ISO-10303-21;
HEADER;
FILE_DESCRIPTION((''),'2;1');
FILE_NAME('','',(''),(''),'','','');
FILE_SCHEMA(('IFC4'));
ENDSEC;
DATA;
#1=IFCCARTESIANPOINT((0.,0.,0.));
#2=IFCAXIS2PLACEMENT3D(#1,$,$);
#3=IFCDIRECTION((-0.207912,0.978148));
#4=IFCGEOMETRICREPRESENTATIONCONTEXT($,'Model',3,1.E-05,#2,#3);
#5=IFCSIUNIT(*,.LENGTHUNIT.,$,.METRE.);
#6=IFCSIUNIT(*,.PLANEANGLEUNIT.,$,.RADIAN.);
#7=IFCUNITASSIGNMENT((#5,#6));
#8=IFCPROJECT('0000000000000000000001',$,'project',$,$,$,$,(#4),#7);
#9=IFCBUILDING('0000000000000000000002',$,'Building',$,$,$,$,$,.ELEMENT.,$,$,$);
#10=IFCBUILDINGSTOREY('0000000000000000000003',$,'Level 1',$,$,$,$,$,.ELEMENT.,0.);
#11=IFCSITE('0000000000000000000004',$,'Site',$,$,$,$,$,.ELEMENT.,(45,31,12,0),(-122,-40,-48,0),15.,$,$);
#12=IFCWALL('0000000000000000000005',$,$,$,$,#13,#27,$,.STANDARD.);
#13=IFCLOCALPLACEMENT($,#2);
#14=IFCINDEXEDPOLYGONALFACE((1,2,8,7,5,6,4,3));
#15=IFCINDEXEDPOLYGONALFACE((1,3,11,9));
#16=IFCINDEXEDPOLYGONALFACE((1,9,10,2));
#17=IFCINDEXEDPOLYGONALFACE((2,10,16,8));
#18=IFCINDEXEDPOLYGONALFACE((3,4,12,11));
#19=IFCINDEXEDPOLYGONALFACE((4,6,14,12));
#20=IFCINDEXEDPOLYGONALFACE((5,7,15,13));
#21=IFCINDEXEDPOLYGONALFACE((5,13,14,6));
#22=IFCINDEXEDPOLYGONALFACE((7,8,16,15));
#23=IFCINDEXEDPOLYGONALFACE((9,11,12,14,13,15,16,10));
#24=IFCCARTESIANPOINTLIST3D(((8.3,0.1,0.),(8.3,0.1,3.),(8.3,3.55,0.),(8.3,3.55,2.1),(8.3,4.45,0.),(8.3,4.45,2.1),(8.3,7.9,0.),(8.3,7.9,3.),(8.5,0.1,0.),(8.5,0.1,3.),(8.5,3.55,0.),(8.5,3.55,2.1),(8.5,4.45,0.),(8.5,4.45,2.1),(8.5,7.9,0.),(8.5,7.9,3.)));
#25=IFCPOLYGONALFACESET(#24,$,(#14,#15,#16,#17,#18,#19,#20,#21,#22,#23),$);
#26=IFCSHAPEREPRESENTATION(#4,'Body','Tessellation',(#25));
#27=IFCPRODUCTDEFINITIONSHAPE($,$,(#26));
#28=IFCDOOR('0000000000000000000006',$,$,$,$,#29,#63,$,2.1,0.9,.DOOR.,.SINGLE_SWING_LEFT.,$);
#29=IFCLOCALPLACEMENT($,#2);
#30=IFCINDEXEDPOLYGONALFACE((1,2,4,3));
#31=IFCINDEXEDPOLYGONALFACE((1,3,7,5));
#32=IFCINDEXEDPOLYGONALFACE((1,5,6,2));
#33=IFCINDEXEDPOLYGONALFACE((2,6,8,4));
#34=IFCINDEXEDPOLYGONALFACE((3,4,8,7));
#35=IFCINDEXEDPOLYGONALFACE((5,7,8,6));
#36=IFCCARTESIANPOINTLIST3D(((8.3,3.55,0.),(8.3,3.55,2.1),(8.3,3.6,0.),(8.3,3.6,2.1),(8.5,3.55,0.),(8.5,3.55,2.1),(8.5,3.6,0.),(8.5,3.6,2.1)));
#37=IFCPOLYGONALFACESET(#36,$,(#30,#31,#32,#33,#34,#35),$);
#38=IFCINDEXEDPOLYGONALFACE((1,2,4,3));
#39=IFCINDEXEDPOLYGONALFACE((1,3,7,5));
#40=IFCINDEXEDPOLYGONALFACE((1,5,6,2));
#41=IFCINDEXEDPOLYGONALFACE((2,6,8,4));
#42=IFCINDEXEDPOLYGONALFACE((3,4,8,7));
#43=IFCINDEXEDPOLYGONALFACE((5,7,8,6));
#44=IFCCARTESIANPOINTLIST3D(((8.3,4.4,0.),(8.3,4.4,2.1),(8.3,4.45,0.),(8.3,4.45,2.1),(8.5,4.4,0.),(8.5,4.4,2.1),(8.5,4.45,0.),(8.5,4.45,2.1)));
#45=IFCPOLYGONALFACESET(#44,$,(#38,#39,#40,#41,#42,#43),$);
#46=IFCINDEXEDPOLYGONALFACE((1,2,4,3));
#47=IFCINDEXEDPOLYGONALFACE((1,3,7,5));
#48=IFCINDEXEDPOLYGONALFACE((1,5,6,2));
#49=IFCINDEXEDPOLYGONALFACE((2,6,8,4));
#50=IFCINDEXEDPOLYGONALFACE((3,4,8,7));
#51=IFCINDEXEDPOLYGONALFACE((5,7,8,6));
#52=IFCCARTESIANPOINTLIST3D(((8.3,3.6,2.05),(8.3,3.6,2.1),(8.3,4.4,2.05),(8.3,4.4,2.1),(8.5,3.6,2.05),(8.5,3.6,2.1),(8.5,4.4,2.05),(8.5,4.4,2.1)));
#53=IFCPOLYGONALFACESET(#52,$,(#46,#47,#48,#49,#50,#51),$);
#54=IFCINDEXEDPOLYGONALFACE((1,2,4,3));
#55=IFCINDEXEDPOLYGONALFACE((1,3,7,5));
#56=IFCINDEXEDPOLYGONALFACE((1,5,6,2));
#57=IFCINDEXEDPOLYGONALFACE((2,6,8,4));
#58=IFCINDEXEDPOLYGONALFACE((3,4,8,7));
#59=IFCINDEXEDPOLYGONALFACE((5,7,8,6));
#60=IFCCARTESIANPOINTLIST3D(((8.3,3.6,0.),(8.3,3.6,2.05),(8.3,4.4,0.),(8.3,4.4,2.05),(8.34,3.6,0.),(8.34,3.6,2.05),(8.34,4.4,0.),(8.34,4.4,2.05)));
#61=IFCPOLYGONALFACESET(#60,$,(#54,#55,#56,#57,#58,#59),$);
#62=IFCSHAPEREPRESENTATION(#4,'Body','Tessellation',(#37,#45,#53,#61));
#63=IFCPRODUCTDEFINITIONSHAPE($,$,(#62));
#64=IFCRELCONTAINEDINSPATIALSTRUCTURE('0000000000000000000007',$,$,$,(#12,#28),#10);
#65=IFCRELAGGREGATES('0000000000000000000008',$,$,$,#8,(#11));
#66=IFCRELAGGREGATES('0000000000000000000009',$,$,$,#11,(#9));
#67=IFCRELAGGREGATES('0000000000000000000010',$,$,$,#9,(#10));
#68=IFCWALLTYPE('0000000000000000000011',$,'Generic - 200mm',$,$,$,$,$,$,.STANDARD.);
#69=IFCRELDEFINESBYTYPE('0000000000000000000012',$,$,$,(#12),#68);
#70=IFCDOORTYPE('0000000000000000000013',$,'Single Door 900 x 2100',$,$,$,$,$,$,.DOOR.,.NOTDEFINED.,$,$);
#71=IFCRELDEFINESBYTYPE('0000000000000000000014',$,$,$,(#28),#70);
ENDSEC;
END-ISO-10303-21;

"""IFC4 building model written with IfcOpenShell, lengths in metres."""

from ifc_helpers import new_model, si_unit, direction, frame, frame_2d, origin, origin_with_axes, origin_2d, place, context, project, spatial, polyline, rectangle, outline, extrude, type_object, element, fill, save


model = new_model("IFC4")

# Units and contexts
model_context = context("Model", 3, precision=1e-05, world=origin(), true_north=direction((-0.207912, 0.978148)))
ifc_project = project(units=[si_unit("LENGTHUNIT", "METRE"), si_unit("PLANEANGLEUNIT", "RADIAN")], contexts=[model_context])

# Site, building, storey
site = spatial("IfcSite", under=ifc_project, Name="Site", CompositionType="ELEMENT", RefLatitude=(45, 31, 12, 0), RefLongitude=(-122, -40, -48, 0), RefElevation=15.0)
building = spatial("IfcBuilding", under=site, Name="Building", CompositionType="ELEMENT")
storey = spatial("IfcBuildingStorey", under=building, Name="Level 1", CompositionType="ELEMENT", Elevation=0.0)

# Shared definitions
wall_type = type_object("IfcWallType", Name="Generic - 200mm", PredefinedType="STANDARD")
door_type = type_object("IfcDoorType", Name="Single Door 900 x 2100", OperationType="NOTDEFINED", PredefinedType="DOOR")

# Wall, opening, door
wall_1_placement = place(None, frame((8.4, 0.0, 0.0), z_axis=(0.0, 0.0, 1.0), x_axis=(0.0, 1.0, 0.0)))
wall_1 = element("IfcWall", 1, at=wall_1_placement, inside=storey, type_object=wall_type, PredefinedType="STANDARD", context=model_context, shape_type="SweptSolid", body=[
    extrude(outline(polyline([(0.1, -0.1), (7.9, -0.1), (7.9, 0.1), (0.1, 0.1), (0.1, -0.1)])), origin(), (0.0, 0.0, 1.0), 3.0),
])
opening_1_placement = place(wall_1_placement, frame((4.0, 0.0, 0.0), z_axis=(0.0, 0.0, 1.0), x_axis=(1.0, 0.0, 0.0)))
opening_1 = element("IfcOpeningElement", 2, at=opening_1_placement, cuts=wall_1, PredefinedType="OPENING", context=model_context, shape_type="SweptSolid", body=[
    extrude(rectangle(XDim=0.9, YDim=0.202, at=origin_2d()), origin(), (0.0, 0.0, 1.0), 2.1),
])
door_1_placement = place(opening_1_placement, origin_with_axes())
door_1 = element("IfcDoor", 3, at=door_1_placement, inside=storey, type_object=door_type, OperationType="SINGLE_SWING_LEFT", OverallHeight=2.1, OverallWidth=0.9, PredefinedType="DOOR", context=model_context, shape_type="SweptSolid", body=[
    extrude(rectangle(XDim=0.05, YDim=0.2, at=frame_2d((-0.425, 0.0))), origin(), (0.0, 0.0, 1.0), 2.1),
    extrude(rectangle(XDim=0.05, YDim=0.2, at=frame_2d((0.425, 0.0))), origin(), (0.0, 0.0, 1.0), 2.1),
    extrude(rectangle(XDim=0.8, YDim=0.2, at=origin_2d()), frame((0.0, 0.0, 2.05)), (0.0, 0.0, 1.0), 0.05),
    extrude(rectangle(XDim=0.8, YDim=0.04, at=frame_2d((0.0, 0.08))), origin(), (0.0, 0.0, 1.0), 2.05),
])
fill(opening_1, door_1)

save(model, "model.ifc")
